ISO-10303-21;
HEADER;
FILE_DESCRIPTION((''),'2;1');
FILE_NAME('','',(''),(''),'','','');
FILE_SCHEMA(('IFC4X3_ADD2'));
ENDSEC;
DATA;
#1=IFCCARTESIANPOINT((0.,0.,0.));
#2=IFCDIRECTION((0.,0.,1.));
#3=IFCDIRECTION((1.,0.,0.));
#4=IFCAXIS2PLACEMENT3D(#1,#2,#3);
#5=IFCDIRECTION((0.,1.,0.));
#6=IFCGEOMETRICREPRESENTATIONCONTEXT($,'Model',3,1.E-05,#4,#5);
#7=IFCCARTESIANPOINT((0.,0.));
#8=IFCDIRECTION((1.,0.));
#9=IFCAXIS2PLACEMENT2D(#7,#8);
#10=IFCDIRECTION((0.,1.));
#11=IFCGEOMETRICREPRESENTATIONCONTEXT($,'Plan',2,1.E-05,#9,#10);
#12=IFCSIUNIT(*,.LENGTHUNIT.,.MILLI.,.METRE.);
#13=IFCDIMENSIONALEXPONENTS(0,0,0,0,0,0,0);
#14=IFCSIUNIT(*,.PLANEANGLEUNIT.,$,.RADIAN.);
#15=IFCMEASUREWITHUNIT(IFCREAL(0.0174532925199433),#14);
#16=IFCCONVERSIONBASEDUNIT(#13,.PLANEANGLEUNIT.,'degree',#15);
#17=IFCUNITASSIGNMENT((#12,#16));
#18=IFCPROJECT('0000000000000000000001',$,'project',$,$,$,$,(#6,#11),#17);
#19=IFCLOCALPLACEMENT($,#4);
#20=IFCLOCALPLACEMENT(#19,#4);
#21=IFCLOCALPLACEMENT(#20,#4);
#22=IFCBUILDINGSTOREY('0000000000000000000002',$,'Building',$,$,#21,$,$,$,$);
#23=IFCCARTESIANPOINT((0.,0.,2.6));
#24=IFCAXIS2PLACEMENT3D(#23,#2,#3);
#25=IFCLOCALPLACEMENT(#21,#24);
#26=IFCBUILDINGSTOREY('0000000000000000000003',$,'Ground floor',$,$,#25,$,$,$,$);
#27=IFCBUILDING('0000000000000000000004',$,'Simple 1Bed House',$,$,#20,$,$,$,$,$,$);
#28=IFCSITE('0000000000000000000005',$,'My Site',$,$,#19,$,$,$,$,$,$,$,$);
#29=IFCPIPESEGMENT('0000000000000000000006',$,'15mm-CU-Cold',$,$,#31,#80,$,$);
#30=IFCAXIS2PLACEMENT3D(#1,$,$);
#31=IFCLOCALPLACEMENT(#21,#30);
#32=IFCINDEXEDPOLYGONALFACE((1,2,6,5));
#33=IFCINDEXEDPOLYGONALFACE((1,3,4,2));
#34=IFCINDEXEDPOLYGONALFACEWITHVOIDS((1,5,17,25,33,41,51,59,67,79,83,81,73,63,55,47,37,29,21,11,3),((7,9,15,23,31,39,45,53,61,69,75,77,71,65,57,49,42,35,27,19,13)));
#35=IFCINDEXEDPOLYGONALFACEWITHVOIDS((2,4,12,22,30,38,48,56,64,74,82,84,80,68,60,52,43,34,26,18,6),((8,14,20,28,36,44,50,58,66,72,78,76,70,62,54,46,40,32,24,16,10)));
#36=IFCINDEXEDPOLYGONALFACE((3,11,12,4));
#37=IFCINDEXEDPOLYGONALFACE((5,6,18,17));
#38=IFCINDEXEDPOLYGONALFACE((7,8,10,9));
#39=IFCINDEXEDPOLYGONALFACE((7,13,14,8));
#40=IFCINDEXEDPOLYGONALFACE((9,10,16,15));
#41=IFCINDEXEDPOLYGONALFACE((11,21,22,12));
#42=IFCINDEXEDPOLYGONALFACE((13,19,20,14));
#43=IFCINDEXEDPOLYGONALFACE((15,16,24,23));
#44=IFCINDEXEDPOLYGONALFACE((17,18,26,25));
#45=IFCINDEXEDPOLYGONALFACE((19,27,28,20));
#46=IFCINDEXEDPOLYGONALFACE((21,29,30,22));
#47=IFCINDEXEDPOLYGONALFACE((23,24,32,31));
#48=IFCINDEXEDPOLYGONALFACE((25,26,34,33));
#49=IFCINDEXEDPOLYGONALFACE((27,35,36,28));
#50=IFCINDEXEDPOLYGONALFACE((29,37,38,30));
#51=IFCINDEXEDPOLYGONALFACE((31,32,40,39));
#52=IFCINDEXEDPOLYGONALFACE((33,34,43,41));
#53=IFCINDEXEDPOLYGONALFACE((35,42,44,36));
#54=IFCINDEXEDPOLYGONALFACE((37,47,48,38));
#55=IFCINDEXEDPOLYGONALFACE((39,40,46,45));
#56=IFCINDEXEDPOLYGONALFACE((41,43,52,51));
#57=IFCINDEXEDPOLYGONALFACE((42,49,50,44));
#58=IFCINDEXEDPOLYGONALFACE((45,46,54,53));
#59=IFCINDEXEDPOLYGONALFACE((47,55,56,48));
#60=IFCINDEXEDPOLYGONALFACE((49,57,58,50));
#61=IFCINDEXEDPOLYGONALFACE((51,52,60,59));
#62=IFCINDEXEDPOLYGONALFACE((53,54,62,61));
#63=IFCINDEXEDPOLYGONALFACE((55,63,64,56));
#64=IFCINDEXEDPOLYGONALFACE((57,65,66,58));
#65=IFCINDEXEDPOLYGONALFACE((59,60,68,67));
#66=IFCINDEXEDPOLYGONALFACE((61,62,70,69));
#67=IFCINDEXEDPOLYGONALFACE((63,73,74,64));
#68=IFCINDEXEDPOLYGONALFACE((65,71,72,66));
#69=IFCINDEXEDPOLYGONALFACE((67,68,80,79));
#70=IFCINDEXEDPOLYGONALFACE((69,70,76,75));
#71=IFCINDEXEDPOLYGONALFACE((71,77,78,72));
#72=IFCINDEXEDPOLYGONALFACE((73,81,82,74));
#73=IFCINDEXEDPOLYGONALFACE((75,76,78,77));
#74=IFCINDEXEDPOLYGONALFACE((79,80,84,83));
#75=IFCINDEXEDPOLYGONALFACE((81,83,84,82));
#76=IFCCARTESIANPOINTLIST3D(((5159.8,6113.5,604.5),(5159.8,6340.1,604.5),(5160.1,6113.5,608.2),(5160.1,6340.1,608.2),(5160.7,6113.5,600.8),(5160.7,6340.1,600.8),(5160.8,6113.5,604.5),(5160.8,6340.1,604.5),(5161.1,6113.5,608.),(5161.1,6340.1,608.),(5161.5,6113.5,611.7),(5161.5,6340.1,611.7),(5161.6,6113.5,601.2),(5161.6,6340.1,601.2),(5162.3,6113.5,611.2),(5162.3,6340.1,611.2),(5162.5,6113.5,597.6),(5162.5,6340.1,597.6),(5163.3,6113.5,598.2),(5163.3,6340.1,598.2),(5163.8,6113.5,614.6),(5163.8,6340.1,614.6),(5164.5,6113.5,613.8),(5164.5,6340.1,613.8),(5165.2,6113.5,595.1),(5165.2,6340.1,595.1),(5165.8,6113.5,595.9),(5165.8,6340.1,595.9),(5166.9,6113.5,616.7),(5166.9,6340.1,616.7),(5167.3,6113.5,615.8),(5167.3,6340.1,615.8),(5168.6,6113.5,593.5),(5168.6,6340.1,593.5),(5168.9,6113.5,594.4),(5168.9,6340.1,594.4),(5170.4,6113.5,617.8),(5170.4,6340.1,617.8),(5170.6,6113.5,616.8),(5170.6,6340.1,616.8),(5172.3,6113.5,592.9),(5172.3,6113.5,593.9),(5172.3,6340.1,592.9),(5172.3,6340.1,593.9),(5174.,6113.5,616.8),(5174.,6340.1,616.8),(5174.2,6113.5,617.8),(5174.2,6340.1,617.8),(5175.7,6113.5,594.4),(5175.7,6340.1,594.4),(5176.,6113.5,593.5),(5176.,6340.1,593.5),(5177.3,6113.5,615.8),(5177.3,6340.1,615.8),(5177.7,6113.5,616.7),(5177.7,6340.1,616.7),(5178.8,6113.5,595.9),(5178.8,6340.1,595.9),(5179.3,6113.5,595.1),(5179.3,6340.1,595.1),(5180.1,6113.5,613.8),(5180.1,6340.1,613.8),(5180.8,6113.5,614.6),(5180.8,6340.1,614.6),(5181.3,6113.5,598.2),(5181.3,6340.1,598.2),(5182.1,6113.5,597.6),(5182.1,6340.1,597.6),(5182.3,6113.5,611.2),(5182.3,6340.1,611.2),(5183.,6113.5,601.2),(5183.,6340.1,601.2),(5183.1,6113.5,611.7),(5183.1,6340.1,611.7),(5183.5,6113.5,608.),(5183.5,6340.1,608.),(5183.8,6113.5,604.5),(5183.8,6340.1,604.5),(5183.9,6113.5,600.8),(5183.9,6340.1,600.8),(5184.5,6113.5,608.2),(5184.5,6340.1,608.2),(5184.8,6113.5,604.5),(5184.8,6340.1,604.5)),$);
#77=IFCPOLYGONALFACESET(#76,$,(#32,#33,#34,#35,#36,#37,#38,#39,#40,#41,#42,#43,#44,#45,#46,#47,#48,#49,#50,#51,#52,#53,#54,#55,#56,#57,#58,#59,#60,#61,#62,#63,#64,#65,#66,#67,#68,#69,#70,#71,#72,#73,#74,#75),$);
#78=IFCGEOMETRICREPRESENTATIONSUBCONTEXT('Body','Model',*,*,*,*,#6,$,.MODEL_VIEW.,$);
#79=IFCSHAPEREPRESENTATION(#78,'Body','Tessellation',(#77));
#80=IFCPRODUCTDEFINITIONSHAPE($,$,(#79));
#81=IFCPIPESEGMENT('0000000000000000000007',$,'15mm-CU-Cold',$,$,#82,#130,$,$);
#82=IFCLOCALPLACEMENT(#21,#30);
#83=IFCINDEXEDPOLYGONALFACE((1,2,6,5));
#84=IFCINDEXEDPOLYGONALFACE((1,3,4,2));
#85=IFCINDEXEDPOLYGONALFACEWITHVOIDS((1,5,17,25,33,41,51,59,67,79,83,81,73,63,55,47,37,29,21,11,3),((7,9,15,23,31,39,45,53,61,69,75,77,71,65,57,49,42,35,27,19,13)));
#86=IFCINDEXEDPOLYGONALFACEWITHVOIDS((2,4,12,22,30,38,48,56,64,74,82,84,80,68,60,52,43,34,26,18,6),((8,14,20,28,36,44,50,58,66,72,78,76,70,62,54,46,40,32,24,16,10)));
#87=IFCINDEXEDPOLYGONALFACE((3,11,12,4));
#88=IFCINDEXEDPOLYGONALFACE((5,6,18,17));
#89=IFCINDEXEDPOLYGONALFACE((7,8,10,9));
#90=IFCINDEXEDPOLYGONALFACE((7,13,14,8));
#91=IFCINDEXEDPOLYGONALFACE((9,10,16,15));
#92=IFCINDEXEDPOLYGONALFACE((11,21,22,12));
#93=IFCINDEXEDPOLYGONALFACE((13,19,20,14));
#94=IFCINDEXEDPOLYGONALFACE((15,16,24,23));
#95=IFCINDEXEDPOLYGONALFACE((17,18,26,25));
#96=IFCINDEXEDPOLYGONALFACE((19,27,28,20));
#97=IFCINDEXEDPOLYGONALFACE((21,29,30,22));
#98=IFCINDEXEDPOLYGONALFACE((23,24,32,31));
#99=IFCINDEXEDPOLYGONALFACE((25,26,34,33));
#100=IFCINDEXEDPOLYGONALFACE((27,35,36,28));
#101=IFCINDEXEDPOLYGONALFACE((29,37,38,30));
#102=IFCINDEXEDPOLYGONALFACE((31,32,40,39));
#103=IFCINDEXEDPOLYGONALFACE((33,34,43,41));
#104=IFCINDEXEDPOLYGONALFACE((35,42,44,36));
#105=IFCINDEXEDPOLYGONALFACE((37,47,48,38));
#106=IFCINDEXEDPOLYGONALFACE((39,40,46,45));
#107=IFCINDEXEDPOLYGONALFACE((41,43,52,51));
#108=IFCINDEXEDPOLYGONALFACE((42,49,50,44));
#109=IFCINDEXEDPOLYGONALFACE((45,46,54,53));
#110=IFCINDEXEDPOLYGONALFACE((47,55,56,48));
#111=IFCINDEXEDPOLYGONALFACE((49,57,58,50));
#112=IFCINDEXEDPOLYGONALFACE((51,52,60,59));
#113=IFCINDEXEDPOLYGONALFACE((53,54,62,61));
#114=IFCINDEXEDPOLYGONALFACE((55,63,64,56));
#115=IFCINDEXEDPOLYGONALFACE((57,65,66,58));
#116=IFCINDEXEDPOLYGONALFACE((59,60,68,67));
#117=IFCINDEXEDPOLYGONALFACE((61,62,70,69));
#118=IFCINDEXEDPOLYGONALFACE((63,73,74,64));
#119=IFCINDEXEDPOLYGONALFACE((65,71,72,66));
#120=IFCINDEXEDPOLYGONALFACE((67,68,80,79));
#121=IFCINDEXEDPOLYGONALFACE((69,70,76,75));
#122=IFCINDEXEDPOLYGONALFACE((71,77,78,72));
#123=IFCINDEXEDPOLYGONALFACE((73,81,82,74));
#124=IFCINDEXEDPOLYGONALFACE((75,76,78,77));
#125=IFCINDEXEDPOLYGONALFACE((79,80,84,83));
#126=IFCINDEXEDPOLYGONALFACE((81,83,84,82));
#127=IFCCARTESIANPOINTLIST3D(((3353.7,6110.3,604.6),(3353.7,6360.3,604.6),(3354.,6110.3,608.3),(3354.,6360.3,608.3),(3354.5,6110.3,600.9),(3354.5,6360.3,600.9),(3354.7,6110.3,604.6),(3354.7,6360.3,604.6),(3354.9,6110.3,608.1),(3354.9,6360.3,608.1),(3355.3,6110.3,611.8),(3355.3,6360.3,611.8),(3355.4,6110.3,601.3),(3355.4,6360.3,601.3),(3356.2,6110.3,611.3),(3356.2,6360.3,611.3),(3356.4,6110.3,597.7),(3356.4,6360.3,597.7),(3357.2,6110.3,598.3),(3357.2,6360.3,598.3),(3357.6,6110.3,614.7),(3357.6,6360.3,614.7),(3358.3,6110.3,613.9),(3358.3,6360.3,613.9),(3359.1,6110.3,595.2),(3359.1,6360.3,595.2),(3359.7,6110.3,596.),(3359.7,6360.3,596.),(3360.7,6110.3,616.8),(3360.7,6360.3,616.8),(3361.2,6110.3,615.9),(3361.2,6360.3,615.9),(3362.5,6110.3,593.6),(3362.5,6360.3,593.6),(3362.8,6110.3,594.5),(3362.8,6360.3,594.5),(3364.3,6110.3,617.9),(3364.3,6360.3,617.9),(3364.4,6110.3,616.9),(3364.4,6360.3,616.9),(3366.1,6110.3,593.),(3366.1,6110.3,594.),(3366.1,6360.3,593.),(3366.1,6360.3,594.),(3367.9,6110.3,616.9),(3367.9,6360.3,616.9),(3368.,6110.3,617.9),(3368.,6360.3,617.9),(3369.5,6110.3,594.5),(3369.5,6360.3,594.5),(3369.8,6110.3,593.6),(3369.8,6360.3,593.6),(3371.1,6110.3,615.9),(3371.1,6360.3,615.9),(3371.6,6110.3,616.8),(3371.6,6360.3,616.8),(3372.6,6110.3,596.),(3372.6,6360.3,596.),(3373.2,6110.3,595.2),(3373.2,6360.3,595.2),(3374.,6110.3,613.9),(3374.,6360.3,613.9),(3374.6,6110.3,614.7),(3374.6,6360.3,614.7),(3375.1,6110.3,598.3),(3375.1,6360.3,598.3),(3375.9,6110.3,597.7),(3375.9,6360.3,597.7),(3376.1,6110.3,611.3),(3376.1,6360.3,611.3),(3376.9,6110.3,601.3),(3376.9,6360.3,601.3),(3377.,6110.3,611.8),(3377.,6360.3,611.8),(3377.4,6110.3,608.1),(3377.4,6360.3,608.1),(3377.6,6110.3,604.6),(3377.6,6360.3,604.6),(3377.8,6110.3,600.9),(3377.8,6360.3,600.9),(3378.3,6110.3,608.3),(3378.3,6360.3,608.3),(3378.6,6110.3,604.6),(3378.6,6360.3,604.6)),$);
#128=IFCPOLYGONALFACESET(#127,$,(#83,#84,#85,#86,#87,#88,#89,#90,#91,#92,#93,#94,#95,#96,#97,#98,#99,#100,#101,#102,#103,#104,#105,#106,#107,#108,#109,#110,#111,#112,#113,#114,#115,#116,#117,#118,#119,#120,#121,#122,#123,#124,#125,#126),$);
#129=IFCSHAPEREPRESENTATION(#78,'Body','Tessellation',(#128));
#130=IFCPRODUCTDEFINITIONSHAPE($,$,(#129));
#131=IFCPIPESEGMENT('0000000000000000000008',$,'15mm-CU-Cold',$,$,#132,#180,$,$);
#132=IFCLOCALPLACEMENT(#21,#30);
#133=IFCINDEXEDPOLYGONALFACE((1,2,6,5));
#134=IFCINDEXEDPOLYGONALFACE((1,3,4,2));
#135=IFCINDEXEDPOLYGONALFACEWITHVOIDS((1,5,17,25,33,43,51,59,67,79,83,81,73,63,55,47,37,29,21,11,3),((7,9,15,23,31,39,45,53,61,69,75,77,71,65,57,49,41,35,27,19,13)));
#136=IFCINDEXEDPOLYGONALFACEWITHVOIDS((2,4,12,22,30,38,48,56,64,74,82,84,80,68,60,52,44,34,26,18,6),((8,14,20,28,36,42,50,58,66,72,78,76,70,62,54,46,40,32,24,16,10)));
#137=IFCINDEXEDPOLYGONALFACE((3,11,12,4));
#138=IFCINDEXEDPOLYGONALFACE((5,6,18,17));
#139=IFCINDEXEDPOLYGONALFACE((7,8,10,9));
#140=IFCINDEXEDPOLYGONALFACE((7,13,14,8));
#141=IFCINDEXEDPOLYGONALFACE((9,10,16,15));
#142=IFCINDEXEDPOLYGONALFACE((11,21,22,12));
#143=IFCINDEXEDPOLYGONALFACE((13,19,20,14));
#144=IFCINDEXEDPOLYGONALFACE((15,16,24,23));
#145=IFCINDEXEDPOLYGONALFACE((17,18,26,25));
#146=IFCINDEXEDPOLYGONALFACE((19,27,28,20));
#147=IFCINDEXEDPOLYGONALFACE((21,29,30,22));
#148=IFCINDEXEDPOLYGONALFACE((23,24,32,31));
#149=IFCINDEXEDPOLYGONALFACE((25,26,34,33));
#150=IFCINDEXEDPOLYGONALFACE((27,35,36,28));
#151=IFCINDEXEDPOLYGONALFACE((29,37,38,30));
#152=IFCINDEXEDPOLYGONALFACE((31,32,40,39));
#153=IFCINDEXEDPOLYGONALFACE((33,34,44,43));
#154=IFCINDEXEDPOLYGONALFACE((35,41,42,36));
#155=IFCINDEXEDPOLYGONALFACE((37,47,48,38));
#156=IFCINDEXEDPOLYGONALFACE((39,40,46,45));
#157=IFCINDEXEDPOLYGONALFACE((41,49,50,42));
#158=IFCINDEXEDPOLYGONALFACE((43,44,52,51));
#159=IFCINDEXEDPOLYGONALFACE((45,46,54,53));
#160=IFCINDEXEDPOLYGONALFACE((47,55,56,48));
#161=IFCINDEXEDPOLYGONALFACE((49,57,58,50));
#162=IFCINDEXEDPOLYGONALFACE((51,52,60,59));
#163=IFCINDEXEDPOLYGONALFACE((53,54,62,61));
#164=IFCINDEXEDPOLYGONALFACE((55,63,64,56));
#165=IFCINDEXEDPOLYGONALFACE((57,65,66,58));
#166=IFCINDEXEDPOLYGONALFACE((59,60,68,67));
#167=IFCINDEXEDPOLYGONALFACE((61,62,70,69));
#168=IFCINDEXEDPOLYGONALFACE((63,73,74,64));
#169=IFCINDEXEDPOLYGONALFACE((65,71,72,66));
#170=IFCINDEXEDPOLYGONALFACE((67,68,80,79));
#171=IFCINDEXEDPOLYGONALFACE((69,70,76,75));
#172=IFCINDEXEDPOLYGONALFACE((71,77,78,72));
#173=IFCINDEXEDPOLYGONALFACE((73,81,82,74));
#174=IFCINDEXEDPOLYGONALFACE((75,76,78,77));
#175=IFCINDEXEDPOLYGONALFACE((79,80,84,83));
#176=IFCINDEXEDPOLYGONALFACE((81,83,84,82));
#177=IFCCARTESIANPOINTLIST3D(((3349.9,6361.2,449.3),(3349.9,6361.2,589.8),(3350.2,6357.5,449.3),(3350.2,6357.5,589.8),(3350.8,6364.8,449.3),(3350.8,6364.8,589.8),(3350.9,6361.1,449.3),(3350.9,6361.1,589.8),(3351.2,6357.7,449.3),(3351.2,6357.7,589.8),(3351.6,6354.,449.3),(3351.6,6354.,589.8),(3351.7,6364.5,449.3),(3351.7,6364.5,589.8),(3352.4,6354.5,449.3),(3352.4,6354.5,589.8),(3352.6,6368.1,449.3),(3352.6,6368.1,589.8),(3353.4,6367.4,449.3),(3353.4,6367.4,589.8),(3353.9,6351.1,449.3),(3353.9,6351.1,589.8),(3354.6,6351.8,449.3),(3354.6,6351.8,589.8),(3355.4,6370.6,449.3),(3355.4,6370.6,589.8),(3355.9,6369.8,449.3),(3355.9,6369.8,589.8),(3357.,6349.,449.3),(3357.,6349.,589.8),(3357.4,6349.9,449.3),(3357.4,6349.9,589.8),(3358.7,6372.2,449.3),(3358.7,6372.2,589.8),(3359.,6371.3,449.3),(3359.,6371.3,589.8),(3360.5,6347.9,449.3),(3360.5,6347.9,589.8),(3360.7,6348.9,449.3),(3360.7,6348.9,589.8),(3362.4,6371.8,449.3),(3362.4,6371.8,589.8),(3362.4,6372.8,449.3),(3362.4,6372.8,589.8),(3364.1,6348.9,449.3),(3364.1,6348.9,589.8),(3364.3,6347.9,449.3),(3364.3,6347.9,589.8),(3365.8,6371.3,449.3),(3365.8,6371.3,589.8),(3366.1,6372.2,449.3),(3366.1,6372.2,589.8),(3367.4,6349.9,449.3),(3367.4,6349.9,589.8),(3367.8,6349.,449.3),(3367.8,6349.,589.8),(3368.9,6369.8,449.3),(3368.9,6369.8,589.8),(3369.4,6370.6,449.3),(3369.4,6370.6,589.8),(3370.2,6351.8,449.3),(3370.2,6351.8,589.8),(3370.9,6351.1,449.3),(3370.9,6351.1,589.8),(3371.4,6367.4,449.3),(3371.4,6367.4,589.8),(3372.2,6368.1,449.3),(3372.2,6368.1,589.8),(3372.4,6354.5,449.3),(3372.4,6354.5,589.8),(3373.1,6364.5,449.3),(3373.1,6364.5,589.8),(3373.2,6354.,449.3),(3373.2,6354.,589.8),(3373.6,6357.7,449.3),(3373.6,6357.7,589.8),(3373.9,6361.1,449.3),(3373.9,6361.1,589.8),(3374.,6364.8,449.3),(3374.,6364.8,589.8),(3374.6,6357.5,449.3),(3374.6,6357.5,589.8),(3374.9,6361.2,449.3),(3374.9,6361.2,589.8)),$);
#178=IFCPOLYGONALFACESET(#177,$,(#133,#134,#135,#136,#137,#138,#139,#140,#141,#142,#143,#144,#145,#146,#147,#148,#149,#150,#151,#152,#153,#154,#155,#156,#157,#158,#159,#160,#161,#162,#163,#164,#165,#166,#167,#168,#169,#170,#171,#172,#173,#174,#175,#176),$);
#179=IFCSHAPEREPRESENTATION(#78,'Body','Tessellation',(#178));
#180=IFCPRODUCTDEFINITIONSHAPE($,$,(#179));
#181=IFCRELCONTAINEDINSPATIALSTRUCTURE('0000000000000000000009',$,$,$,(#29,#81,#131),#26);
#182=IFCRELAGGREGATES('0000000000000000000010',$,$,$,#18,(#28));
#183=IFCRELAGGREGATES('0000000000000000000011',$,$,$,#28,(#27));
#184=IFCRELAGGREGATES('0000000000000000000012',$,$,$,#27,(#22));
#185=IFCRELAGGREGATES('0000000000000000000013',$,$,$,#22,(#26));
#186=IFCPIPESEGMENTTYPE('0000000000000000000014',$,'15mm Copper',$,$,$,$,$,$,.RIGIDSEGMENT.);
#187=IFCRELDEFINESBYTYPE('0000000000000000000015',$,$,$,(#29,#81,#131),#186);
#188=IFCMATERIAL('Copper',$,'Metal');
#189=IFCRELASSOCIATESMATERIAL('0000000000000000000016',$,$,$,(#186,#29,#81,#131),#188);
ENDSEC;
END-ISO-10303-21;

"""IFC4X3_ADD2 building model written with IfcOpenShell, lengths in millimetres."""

from ifc_helpers import new_model, entity, si_unit, converted_unit, direction, frame, origin_with_axes, origin_2d_with_axis, place, context, subcontext, project, spatial, hollow_circle, extrude, material, material_profile, profile_set, profile_usage, type_object, element, save


model = new_model("IFC4X3_ADD2")

# Units and contexts
model_context = context("Model", 3, precision=1e-05, world=origin_with_axes(), true_north=direction((0.0, 1.0, 0.0)))
plan_context = context("Plan", 2, precision=1e-05, world=origin_2d_with_axis(), true_north=direction((0.0, 1.0)))
body_context_1 = subcontext(model_context, "Body", "Model", "MODEL_VIEW")
ifc_project = project(units=[si_unit("LENGTHUNIT", "METRE", prefix="MILLI"), converted_unit("PLANEANGLEUNIT", "degree", entity("IfcReal", 0.0174532925199433), si_unit("PLANEANGLEUNIT", "RADIAN"), dimensions=[0, 0, 0, 0, 0, 0, 0])], contexts=[model_context, plan_context])

# Site, building, storeys
site_placement = place(None, origin_with_axes())
site = spatial("IfcSite", under=ifc_project, at=site_placement, Name="My Site")
building_placement = place(site_placement, origin_with_axes())
building = spatial("IfcBuilding", under=site, at=building_placement, Name="Simple 1Bed House")
storey_1_placement = place(building_placement, origin_with_axes())
storey_1 = spatial("IfcBuildingStorey", under=building, at=storey_1_placement, Name="Building")
storey_2_placement = place(storey_1_placement, frame((0.0, 0.0, 2.6), z_axis=(0.0, 0.0, 1.0), x_axis=(1.0, 0.0, 0.0)))
storey_2 = spatial("IfcBuildingStorey", under=storey_1, at=storey_2_placement, Name="Ground floor")

# Pipe segments
ifc_material_1 = material(Name="Copper", Category="Metal")
ifc_material_profile = material_profile(ifc_material_1, hollow_circle(Radius=12.5, WallThickness=1.0))
ifc_profile_set = profile_set([ifc_material_profile])
pipe_segment_type = type_object("IfcPipeSegmentType", Name="15mm Copper", PredefinedType="RIGIDSEGMENT", material=ifc_profile_set)
ifc_profile_usage_1 = profile_usage(ifc_profile_set, cardinal=5)
pipe_segment_1_placement = place(storey_2_placement, frame((5172.3, 6340.1, 602.8), z_axis=(0.0, -1.0, 0.0), x_axis=(0.0, 0.0, -1.0)))
element("IfcPipeSegment", 1, at=pipe_segment_1_placement, inside=storey_2, type_object=pipe_segment_type, material=ifc_profile_usage_1, Name="15mm-CU-Cold", context=body_context_1, shape_type="SweptSolid", body=[
    extrude(hollow_circle(Radius=12.5, WallThickness=1.0), origin_with_axes(), (0.0, 0.0, 1.0), 226.6),
])
ifc_profile_usage_2 = profile_usage(ifc_profile_set, cardinal=5)
pipe_segment_2_placement = place(storey_2_placement, frame((3366.1, 6360.3, 602.9), z_axis=(0.0, -1.0, 0.0), x_axis=(0.0, 0.0, -1.0)))
element("IfcPipeSegment", 2, at=pipe_segment_2_placement, inside=storey_2, type_object=pipe_segment_type, material=ifc_profile_usage_2, Name="15mm-CU-Cold", context=body_context_1, shape_type="SweptSolid", body=[
    extrude(hollow_circle(Radius=12.5, WallThickness=1.0), origin_with_axes(), (0.0, 0.0, 1.0), 250.0),
])
ifc_profile_usage_3 = profile_usage(ifc_profile_set, cardinal=5)
pipe_segment_3_placement = place(storey_2_placement, frame((3362.4, 6360.3, 587.2), z_axis=(0.0, 0.0, -1.0), x_axis=(0.0, 1.0, 0.0)))
element("IfcPipeSegment", 3, at=pipe_segment_3_placement, inside=storey_2, type_object=pipe_segment_type, material=ifc_profile_usage_3, Name="15mm-CU-Cold", context=body_context_1, shape_type="SweptSolid", body=[
    extrude(hollow_circle(Radius=12.5, WallThickness=1.0), origin_with_axes(), (0.0, 0.0, 1.0), 140.6),
])

save(model, "model.ifc")
